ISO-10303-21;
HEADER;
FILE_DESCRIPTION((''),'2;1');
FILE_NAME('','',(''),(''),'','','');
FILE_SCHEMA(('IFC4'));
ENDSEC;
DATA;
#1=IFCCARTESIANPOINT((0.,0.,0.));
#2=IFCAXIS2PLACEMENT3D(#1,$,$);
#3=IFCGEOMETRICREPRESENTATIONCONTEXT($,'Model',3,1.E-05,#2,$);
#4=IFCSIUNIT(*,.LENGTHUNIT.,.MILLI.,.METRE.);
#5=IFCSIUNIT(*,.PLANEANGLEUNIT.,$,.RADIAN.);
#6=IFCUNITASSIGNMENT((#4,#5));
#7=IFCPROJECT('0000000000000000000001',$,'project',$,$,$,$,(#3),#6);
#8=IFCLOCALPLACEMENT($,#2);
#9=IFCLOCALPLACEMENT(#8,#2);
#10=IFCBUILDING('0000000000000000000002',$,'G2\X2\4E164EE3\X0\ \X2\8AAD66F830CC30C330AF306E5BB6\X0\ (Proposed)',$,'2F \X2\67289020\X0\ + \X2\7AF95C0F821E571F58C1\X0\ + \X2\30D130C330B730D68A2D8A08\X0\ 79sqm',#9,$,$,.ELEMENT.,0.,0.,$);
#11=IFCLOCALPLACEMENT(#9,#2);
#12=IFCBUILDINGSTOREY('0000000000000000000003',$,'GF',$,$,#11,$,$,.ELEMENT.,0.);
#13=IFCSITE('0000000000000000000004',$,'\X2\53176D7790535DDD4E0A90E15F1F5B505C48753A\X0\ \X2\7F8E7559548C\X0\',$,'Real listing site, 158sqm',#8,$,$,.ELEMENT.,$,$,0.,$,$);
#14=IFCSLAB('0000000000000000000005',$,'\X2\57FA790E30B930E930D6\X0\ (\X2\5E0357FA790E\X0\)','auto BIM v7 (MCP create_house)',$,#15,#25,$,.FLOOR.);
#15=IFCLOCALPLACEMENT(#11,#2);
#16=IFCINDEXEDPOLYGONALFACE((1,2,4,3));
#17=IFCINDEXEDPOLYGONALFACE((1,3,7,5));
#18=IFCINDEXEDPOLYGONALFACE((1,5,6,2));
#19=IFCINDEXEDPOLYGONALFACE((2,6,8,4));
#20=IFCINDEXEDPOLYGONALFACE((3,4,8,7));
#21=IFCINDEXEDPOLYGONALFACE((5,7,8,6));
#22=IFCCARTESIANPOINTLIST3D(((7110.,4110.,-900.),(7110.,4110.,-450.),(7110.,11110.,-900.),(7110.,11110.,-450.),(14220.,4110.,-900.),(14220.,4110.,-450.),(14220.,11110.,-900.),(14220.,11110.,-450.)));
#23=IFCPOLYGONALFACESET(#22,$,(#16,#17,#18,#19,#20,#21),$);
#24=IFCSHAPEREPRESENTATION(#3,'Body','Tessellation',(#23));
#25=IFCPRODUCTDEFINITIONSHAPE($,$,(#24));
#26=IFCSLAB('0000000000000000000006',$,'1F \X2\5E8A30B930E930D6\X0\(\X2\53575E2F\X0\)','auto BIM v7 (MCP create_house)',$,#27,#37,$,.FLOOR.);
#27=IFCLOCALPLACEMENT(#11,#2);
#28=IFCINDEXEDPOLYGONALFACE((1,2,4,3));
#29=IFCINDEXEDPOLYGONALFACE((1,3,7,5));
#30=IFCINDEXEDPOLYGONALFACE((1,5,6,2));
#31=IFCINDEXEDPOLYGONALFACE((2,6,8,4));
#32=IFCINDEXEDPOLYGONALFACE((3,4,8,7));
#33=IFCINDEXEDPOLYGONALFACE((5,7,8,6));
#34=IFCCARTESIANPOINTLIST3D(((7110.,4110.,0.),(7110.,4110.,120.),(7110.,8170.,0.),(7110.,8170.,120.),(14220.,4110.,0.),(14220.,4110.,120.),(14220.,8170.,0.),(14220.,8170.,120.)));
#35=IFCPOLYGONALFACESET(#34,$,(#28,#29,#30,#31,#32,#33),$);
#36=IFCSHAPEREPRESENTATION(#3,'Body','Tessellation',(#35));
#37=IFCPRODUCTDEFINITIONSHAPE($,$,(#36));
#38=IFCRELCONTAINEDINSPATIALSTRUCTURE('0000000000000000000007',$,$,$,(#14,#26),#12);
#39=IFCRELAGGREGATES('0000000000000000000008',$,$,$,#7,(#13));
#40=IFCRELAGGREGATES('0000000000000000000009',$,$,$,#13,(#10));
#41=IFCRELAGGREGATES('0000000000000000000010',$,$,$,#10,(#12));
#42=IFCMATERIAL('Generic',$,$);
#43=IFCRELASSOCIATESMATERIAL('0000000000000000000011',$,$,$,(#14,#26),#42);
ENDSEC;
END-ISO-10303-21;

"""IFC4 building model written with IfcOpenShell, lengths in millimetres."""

from ifc_helpers import new_model, si_unit, frame, frame_2d, origin, place, context, project, spatial, rectangle, extrude, material, element, save


model = new_model("IFC4")

# Units and contexts
model_context = context("Model", 3, precision=1e-05, world=origin())
ifc_project = project(units=[si_unit("LENGTHUNIT", "METRE", prefix="MILLI"), si_unit("PLANEANGLEUNIT", "RADIAN")], contexts=[model_context])

# Site, building, storey
site_placement = place(None, origin())
site = spatial("IfcSite", under=ifc_project, at=site_placement, Name="北海道川上郡弟子屈町 美留和", ObjectType="Real listing site, 158sqm", CompositionType="ELEMENT", RefElevation=0.0)
building_placement = place(site_placement, origin())
building = spatial("IfcBuilding", under=site, at=building_placement, Name="G2世代 読書ヌックの家 (Proposed)", ObjectType="2F 木造 + 竹小舞土壁 + パッシブ設計 79sqm", CompositionType="ELEMENT", ElevationOfRefHeight=0.0, ElevationOfTerrain=0.0)
storey_placement = place(building_placement, origin())
storey = spatial("IfcBuildingStorey", under=building, at=storey_placement, Name="GF", CompositionType="ELEMENT", Elevation=0.0)

# Slabs
ifc_material = material(Name="Generic")
slab_1_placement = place(storey_placement, frame((3555.0, 2055.0, -450.0)))
element("IfcSlab", 1, at=slab_1_placement, inside=storey, material=ifc_material, Name="基礎スラブ (布基礎)", Description="auto BIM v7 (MCP create_house)", PredefinedType="FLOOR", context=model_context, shape_type="SweptSolid", body=[
    extrude(rectangle(XDim=7110.0, YDim=7000.0, at=frame_2d((3555.0, 3500.0))), frame((3555.0, 2055.0, -450.0)), (0.0, 0.0, 1.0), 450.0),
])
slab_2_placement = place(storey_placement, frame((3555.0, 2055.0, 0.0)))
element("IfcSlab", 2, at=slab_2_placement, inside=storey, material=ifc_material, Name="1F 床スラブ(南帯)", Description="auto BIM v7 (MCP create_house)", PredefinedType="FLOOR", context=model_context, shape_type="SweptSolid", body=[
    extrude(rectangle(XDim=7110.0, YDim=4060.0, at=frame_2d((3555.0, 2030.0))), frame((3555.0, 2055.0, 0.0)), (0.0, 0.0, 1.0), 120.0),
])

save(model, "model.ifc")
